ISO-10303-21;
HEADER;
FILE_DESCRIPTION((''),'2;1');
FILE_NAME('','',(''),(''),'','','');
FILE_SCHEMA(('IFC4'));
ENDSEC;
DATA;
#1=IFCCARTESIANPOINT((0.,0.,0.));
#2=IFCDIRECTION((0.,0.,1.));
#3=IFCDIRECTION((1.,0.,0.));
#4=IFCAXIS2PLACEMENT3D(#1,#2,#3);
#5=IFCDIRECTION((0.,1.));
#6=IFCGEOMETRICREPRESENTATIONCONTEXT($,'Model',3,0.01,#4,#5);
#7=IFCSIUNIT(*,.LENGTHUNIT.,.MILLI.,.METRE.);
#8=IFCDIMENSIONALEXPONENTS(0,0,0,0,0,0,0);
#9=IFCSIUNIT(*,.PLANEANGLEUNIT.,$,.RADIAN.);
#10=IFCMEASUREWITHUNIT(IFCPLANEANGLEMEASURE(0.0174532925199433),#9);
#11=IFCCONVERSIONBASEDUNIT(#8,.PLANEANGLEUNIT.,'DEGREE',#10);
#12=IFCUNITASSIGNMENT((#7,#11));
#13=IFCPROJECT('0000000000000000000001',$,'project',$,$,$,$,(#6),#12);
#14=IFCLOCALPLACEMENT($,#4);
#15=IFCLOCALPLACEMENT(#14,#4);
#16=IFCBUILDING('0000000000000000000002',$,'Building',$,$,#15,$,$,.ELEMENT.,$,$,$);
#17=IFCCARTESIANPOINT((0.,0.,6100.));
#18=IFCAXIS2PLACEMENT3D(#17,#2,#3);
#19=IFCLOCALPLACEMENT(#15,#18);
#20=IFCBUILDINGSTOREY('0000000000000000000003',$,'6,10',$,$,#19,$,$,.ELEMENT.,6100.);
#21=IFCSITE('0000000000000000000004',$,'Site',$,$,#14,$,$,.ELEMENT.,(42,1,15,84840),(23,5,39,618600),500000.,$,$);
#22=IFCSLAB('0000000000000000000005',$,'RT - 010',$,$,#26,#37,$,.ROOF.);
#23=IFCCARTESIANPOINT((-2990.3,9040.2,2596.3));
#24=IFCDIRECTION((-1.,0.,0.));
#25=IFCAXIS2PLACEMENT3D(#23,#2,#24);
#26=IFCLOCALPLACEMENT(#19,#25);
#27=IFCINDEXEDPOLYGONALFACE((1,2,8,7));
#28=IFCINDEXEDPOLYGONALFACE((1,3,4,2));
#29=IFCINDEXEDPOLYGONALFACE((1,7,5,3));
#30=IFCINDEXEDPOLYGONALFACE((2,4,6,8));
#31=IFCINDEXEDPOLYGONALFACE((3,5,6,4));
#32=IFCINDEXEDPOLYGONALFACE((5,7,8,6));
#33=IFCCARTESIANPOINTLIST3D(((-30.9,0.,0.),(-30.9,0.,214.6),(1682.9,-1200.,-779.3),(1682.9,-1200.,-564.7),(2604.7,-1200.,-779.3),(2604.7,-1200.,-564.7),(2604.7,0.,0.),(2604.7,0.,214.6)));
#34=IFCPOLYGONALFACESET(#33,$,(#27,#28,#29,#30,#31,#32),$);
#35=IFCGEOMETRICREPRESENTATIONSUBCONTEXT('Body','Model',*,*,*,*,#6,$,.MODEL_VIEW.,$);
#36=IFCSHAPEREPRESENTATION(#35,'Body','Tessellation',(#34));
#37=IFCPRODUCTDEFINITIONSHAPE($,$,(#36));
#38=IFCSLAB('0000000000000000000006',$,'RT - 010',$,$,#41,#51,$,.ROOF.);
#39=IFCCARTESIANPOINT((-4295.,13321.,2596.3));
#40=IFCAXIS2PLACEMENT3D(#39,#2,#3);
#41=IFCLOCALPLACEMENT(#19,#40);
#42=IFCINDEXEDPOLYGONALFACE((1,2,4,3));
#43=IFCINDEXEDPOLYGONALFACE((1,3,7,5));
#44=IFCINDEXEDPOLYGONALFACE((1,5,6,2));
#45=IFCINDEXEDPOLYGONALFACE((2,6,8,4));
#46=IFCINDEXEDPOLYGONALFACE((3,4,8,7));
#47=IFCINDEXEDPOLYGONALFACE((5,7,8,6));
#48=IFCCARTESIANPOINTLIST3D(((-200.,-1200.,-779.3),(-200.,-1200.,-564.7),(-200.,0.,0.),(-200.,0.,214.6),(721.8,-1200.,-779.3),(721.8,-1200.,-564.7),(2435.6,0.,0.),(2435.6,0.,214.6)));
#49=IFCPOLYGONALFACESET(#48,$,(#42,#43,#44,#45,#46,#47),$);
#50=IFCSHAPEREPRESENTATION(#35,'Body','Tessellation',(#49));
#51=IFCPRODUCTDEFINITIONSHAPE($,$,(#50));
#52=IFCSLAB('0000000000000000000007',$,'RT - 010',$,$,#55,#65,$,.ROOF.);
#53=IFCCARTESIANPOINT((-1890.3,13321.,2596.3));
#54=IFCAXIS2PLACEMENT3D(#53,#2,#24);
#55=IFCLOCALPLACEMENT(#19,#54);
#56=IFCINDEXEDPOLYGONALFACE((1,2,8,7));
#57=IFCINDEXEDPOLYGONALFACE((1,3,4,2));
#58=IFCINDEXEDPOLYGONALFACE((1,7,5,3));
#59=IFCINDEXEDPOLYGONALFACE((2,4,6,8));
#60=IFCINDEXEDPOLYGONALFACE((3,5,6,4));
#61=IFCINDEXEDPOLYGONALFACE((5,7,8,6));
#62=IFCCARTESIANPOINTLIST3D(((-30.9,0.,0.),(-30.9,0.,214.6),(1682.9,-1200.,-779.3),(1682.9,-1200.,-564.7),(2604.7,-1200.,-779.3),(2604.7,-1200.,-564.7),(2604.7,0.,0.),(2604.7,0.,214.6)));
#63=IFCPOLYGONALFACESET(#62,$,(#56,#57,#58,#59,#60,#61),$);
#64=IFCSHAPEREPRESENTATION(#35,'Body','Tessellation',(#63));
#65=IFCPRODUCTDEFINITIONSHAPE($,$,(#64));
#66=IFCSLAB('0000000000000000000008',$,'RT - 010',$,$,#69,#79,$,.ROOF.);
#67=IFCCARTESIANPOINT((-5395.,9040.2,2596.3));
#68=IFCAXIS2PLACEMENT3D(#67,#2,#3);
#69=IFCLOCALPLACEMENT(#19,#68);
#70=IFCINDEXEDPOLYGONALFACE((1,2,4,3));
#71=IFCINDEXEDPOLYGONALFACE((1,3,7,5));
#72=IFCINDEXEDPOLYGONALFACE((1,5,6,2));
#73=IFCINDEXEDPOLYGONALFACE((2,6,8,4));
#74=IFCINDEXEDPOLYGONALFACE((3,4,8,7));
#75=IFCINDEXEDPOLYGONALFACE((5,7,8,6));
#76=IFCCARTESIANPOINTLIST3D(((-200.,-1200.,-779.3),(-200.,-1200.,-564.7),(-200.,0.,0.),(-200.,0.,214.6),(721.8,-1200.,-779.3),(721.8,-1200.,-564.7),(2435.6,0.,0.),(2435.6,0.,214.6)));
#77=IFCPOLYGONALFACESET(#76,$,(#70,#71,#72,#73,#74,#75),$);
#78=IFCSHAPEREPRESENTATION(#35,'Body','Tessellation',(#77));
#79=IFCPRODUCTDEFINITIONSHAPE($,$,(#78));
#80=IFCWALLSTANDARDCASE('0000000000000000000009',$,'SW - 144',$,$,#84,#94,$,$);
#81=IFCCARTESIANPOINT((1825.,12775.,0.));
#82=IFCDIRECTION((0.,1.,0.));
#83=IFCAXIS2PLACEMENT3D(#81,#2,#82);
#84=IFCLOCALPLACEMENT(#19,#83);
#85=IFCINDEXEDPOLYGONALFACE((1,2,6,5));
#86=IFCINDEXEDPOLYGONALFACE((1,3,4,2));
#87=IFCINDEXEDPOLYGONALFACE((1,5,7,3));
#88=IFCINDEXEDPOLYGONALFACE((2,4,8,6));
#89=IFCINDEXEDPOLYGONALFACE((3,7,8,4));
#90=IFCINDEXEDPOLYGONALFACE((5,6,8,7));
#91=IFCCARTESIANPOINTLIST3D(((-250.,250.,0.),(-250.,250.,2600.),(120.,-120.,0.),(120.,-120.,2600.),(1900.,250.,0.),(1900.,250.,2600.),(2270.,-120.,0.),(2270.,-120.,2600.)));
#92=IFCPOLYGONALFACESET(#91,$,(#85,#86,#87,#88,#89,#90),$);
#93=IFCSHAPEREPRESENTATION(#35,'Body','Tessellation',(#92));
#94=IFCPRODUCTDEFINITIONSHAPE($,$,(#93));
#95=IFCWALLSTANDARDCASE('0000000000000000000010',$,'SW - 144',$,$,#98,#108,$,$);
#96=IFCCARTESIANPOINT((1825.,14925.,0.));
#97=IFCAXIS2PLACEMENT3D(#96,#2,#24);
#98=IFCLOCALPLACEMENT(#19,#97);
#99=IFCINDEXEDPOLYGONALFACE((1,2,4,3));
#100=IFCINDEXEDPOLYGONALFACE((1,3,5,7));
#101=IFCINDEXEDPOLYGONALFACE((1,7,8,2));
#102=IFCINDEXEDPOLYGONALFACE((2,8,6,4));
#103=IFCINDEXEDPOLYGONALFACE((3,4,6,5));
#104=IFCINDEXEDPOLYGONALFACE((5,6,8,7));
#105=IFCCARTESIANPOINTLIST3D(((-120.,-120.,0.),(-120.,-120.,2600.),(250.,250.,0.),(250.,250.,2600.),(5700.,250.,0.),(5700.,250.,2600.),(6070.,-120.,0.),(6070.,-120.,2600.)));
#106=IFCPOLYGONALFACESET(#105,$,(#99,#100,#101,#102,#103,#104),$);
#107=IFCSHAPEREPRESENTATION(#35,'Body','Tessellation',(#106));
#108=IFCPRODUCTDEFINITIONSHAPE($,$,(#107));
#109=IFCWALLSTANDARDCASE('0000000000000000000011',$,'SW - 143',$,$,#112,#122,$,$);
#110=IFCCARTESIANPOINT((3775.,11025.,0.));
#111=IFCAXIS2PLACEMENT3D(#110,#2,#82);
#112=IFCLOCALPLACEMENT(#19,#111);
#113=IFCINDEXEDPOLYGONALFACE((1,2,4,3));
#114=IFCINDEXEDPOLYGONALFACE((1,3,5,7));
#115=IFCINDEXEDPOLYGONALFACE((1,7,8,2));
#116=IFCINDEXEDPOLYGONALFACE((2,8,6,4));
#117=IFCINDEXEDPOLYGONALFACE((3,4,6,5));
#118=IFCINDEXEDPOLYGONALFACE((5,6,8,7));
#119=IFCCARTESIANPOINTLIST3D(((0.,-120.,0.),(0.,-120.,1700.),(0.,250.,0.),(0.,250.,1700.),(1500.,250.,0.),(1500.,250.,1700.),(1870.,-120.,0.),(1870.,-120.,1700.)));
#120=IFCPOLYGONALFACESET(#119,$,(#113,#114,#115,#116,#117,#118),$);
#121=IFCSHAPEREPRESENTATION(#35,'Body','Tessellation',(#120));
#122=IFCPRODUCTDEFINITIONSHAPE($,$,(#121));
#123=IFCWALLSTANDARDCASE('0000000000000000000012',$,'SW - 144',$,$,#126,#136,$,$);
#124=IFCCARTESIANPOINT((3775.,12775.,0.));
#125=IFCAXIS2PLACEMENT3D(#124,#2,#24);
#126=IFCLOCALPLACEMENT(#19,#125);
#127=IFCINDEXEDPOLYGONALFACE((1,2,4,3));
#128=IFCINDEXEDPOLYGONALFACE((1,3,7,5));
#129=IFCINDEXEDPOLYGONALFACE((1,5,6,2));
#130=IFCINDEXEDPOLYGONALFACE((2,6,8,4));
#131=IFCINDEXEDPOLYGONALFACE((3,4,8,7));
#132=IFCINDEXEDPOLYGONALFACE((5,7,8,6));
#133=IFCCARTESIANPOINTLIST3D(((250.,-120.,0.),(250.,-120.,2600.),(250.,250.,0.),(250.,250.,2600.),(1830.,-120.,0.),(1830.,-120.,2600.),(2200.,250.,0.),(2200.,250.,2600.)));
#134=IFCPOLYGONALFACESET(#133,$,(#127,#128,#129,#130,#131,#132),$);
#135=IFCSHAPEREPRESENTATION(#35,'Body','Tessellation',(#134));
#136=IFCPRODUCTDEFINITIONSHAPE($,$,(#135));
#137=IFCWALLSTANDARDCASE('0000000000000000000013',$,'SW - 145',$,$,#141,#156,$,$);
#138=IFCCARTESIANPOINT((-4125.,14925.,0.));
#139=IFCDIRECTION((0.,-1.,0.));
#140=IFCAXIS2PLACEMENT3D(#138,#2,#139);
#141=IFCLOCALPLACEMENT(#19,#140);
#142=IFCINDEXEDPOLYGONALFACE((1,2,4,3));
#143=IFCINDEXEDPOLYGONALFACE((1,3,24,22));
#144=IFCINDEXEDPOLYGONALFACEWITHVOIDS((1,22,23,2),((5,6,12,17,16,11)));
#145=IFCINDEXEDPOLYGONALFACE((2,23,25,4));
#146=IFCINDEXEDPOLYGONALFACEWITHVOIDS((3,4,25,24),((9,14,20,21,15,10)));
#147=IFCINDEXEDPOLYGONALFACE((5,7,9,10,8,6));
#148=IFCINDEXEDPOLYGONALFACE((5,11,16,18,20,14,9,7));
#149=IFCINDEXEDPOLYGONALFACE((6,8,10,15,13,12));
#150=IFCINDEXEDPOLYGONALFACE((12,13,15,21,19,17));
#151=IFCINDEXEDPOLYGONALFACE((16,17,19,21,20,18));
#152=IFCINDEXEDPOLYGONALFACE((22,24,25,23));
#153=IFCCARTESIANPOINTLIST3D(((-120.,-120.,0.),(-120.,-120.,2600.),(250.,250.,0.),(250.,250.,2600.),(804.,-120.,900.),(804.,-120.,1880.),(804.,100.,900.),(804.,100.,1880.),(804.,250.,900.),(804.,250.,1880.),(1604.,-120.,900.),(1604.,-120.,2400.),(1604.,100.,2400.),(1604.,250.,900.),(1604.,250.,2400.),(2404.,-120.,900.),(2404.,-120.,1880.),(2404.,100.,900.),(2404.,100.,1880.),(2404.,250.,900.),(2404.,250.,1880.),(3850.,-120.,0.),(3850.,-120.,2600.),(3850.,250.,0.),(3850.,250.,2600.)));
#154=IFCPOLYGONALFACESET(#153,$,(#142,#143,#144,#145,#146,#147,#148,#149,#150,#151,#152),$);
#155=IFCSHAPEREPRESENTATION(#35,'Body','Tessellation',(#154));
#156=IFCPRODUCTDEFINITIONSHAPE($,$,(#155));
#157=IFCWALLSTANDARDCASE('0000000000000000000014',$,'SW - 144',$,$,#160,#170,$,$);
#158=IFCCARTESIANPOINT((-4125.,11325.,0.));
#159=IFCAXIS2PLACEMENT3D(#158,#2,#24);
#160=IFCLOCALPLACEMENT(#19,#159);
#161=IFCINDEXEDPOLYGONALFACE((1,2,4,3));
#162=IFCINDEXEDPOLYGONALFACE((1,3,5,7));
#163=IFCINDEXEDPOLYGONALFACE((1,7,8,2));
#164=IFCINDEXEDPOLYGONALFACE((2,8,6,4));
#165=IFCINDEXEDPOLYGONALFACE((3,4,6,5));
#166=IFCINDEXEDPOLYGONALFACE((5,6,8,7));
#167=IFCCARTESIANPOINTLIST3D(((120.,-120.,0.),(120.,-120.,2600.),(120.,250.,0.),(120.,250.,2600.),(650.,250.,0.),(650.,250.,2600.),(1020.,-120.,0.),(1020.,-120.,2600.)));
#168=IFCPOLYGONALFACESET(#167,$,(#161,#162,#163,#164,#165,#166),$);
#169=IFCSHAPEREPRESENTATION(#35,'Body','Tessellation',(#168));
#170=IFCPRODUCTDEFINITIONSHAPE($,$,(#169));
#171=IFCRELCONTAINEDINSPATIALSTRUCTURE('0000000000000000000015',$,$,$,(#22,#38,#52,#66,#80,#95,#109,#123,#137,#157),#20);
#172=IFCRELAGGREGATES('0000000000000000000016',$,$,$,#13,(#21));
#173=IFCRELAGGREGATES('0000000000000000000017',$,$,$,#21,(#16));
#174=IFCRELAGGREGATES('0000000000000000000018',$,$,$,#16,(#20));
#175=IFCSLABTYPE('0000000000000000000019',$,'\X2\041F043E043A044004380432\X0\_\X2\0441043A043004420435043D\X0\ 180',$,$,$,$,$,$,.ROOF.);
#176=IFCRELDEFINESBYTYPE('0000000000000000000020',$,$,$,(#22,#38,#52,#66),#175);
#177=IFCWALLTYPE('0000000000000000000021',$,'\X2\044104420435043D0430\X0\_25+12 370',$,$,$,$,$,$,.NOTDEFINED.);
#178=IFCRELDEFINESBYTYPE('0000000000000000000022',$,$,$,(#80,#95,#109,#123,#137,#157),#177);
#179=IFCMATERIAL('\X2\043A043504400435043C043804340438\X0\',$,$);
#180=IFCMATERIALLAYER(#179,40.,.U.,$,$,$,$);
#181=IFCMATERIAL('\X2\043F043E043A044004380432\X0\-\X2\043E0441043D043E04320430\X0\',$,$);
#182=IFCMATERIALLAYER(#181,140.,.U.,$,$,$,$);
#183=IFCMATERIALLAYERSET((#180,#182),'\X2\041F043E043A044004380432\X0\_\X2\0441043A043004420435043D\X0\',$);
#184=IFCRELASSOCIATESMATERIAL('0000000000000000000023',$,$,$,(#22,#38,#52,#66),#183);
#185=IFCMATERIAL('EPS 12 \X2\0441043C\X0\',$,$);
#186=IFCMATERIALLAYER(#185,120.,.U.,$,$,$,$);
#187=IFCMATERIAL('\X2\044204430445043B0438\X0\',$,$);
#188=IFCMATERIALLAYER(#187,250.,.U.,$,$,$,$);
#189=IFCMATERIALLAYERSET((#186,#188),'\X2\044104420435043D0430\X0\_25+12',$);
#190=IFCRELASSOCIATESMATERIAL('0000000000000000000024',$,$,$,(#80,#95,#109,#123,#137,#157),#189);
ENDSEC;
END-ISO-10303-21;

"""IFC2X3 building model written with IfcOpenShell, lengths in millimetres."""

from ifc_helpers import new_model, entity, si_unit, converted_unit, direction, frame, origin_with_axes, place, context, subcontext, project, spatial, polyline, outline, extrude, material, layer, layer_set, layer_usage, type_object, element, save


model = new_model("IFC2X3")

# Units and contexts
model_context = context("Model", 3, precision=0.01, world=origin_with_axes(), true_north=direction((0.0, 1.0)))
body_context = subcontext(model_context, "Body", "Model", "MODEL_VIEW")
ifc_project = project(units=[si_unit("LENGTHUNIT", "METRE", prefix="MILLI"), converted_unit("PLANEANGLEUNIT", "DEGREE", entity("IfcPlaneAngleMeasure", 0.0174532925199433), si_unit("PLANEANGLEUNIT", "RADIAN"), dimensions=[0, 0, 0, 0, 0, 0, 0])], contexts=[model_context])

# Site, building, storey
site_placement = place(None, origin_with_axes())
site = spatial("IfcSite", under=ifc_project, at=site_placement, Name="Site", CompositionType="ELEMENT", RefLatitude=(42, 1, 15, 84840), RefLongitude=(23, 5, 39, 618600), RefElevation=500000.0)
building_placement = place(site_placement, origin_with_axes())
building = spatial("IfcBuilding", under=site, at=building_placement, Name="Building", CompositionType="ELEMENT")
storey_placement = place(building_placement, frame((0.0, 0.0, 6100.0), z_axis=(0.0, 0.0, 1.0), x_axis=(1.0, 0.0, 0.0)))
storey = spatial("IfcBuildingStorey", under=building, at=storey_placement, Name="6,10", CompositionType="ELEMENT", Elevation=6100.0)

# Slabs
ifc_material_1 = material(Name="керемиди")
ifc_layer_1 = layer(ifc_material_1, 40.0, ventilated="UNKNOWN")
ifc_material_2 = material(Name="покрив-основа")
ifc_layer_2 = layer(ifc_material_2, 140.0, ventilated="UNKNOWN")
ifc_layer_set_1 = layer_set([ifc_layer_1, ifc_layer_2], Name="Покрив_скатен")
ifc_layer_usage_1 = layer_usage(ifc_layer_set_1, "AXIS3", "NEGATIVE", 180.0)
slab_type = type_object("IfcSlabType", Name="Покрив_скатен 180", PredefinedType="ROOF")
slab_1_placement = place(storey_placement, frame((-2990.3, 9040.2, 2596.3), z_axis=(0.0, 0.0, 1.0), x_axis=(-1.0, 0.0, 0.0)))
element("IfcSlab", 1, at=slab_1_placement, inside=storey, type_object=slab_type, material=ifc_layer_usage_1, Name="RT - 010", PredefinedType="ROOF", context=body_context, shape_type="SweptSolid", body=[
    extrude(outline(polyline([(-30.9, 0.0), (1682.9, -1430.8), (2604.7, -1430.8), (2604.7, 0.0), (-30.9, 0.0)])), frame((0.0, 0.0, 0.0), z_axis=(0.0, -0.544639, 0.838671), x_axis=(1.0, 0.0, 0.0)), (0.0, 0.544639, 0.838671), 214.6),
])
ifc_layer_usage_2 = layer_usage(ifc_layer_set_1, "AXIS3", "NEGATIVE", 180.0)
slab_2_placement = place(storey_placement, frame((-4295.0, 13321.0, 2596.3), z_axis=(0.0, 0.0, 1.0), x_axis=(1.0, 0.0, 0.0)))
element("IfcSlab", 2, at=slab_2_placement, inside=storey, type_object=slab_type, material=ifc_layer_usage_2, Name="RT - 010", PredefinedType="ROOF", context=body_context, shape_type="SweptSolid", body=[
    extrude(outline(polyline([(2435.6, 0.0), (-200.0, 0.0), (-200.0, -1430.8), (721.8, -1430.8), (2435.6, 0.0)])), frame((0.0, 0.0, 0.0), z_axis=(0.0, -0.544639, 0.838671), x_axis=(1.0, 0.0, 0.0)), (0.0, 0.544639, 0.838671), 214.6),
])
ifc_layer_usage_3 = layer_usage(ifc_layer_set_1, "AXIS3", "NEGATIVE", 180.0)
slab_3_placement = place(storey_placement, frame((-1890.3, 13321.0, 2596.3), z_axis=(0.0, 0.0, 1.0), x_axis=(-1.0, 0.0, 0.0)))
element("IfcSlab", 3, at=slab_3_placement, inside=storey, type_object=slab_type, material=ifc_layer_usage_3, Name="RT - 010", PredefinedType="ROOF", context=body_context, shape_type="SweptSolid", body=[
    extrude(outline(polyline([(-30.9, 0.0), (1682.9, -1430.8), (2604.7, -1430.8), (2604.7, 0.0), (-30.9, 0.0)])), frame((0.0, 0.0, 0.0), z_axis=(0.0, -0.544639, 0.838671), x_axis=(1.0, 0.0, 0.0)), (0.0, 0.544639, 0.838671), 214.6),
])
ifc_layer_usage_4 = layer_usage(ifc_layer_set_1, "AXIS3", "NEGATIVE", 180.0)
slab_4_placement = place(storey_placement, frame((-5395.0, 9040.2, 2596.3), z_axis=(0.0, 0.0, 1.0), x_axis=(1.0, 0.0, 0.0)))
element("IfcSlab", 4, at=slab_4_placement, inside=storey, type_object=slab_type, material=ifc_layer_usage_4, Name="RT - 010", PredefinedType="ROOF", context=body_context, shape_type="SweptSolid", body=[
    extrude(outline(polyline([(2435.6, 0.0), (-200.0, 0.0), (-200.0, -1430.8), (721.8, -1430.8), (2435.6, 0.0)])), frame((0.0, 0.0, 0.0), z_axis=(0.0, -0.544639, 0.838671), x_axis=(1.0, 0.0, 0.0)), (0.0, 0.544639, 0.838671), 214.6),
])

# Walls
ifc_material_3 = material(Name="EPS 12 см")
ifc_layer_3 = layer(ifc_material_3, 120.0, ventilated="UNKNOWN")
ifc_material_4 = material(Name="тухли")
ifc_layer_4 = layer(ifc_material_4, 250.0, ventilated="UNKNOWN")
ifc_layer_set_2 = layer_set([ifc_layer_3, ifc_layer_4], Name="стена_25+12")
ifc_layer_usage_5 = layer_usage(ifc_layer_set_2, "AXIS2", "POSITIVE", -120.0)
wall_type_1 = type_object("IfcWallType", Name="стена_25+12 370", PredefinedType="NOTDEFINED")
wall_1_placement = place(storey_placement, frame((1825.0, 12775.0, 0.0), z_axis=(0.0, 0.0, 1.0), x_axis=(0.0, 1.0, 0.0)))
element("IfcWallStandardCase", 5, at=wall_1_placement, inside=storey, type_object=wall_type_1, material=ifc_layer_usage_5, Name="SW - 144", context=body_context, shape_type="SweptSolid", body=[
    extrude(outline(polyline([(120.0, -120.0), (2270.0, -120.0), (1900.0, 250.0), (-250.0, 250.0), (120.0, -120.0)])), origin_with_axes(), (0.0, 0.0, 1.0), 2600.0),
])
ifc_layer_usage_6 = layer_usage(ifc_layer_set_2, "AXIS2", "POSITIVE", -120.0)
wall_2_placement = place(storey_placement, frame((1825.0, 14925.0, 0.0), z_axis=(0.0, 0.0, 1.0), x_axis=(-1.0, 0.0, 0.0)))
element("IfcWallStandardCase", 6, at=wall_2_placement, inside=storey, type_object=wall_type_1, material=ifc_layer_usage_6, Name="SW - 144", context=body_context, shape_type="SweptSolid", body=[
    extrude(outline(polyline([(-120.0, -120.0), (6070.0, -120.0), (5700.0, 250.0), (250.0, 250.0), (-120.0, -120.0)])), origin_with_axes(), (0.0, 0.0, 1.0), 2600.0),
])
ifc_layer_usage_7 = layer_usage(ifc_layer_set_2, "AXIS2", "POSITIVE", -120.0)
wall_3_placement = place(storey_placement, frame((3775.0, 11025.0, 0.0), z_axis=(0.0, 0.0, 1.0), x_axis=(0.0, 1.0, 0.0)))
element("IfcWallStandardCase", 7, at=wall_3_placement, inside=storey, type_object=wall_type_1, material=ifc_layer_usage_7, Name="SW - 143", context=body_context, shape_type="SweptSolid", body=[
    extrude(outline(polyline([(0.0, -120.0), (1870.0, -120.0), (1500.0, 250.0), (0.0, 250.0), (0.0, -120.0)])), origin_with_axes(), (0.0, 0.0, 1.0), 1700.0),
])
ifc_layer_usage_8 = layer_usage(ifc_layer_set_2, "AXIS2", "POSITIVE", -120.0)
wall_4_placement = place(storey_placement, frame((3775.0, 12775.0, 0.0), z_axis=(0.0, 0.0, 1.0), x_axis=(-1.0, 0.0, 0.0)))
element("IfcWallStandardCase", 8, at=wall_4_placement, inside=storey, type_object=wall_type_1, material=ifc_layer_usage_8, Name="SW - 144", context=body_context, shape_type="SweptSolid", body=[
    extrude(outline(polyline([(250.0, -120.0), (1830.0, -120.0), (2200.0, 250.0), (250.0, 250.0), (250.0, -120.0)])), origin_with_axes(), (0.0, 0.0, 1.0), 2600.0),
])

# Wall, openings
ifc_layer_usage_9 = layer_usage(ifc_layer_set_2, "AXIS2", "POSITIVE", -120.0)
wall_5_placement = place(storey_placement, frame((-4125.0, 14925.0, 0.0), z_axis=(0.0, 0.0, 1.0), x_axis=(0.0, -1.0, 0.0)))
wall_5 = element("IfcWallStandardCase", 9, at=wall_5_placement, inside=storey, type_object=wall_type_1, material=ifc_layer_usage_9, Name="SW - 145", context=body_context, shape_type="SweptSolid", body=[
    extrude(outline(polyline([(-120.0, -120.0), (3850.0, -120.0), (3850.0, 250.0), (250.0, 250.0), (-120.0, -120.0)])), origin_with_axes(), (0.0, 0.0, 1.0), 2600.0),
])
opening_1_placement = place(wall_5_placement, frame((2004.0, 0.0, 900.0), z_axis=(0.0, 0.0, 1.0), x_axis=(1.0, 0.0, 0.0)))
element("IfcOpeningElement", 10, at=opening_1_placement, cuts=wall_5, context=body_context, shape_type="SweptSolid", body=[
    extrude(outline(polyline([(-400.0, 0.0), (-400.0, -1500.0), (400.0, -980.0), (400.0, 0.0), (-400.0, 0.0)])), frame((0.0, 100.0, 0.0), z_axis=(0.0, 1.0, 0.0), x_axis=(1.0, 0.0, 0.0)), (0.0, 0.0, -1.0), 590.0),
    extrude(outline(polyline([(400.0, 0.0), (400.0, 980.0), (-400.0, 1500.0), (-400.0, 0.0), (400.0, 0.0)])), frame((0.0, 100.0, 0.0), z_axis=(0.0, -1.0, 0.0), x_axis=(1.0, 0.0, 0.0)), (0.0, 0.0, -1.0), 520.0),
])
opening_2_placement = place(wall_5_placement, frame((1204.0, 0.0, 900.0), z_axis=(0.0, 0.0, 1.0), x_axis=(1.0, 0.0, 0.0)))
element("IfcOpeningElement", 11, at=opening_2_placement, cuts=wall_5, context=body_context, shape_type="SweptSolid", body=[
    extrude(outline(polyline([(-400.0, 0.0), (-400.0, -1500.0), (400.0, -980.0), (400.0, 0.0), (-400.0, 0.0)])), frame((0.0, 100.0, 0.0), z_axis=(0.0, -1.0, 0.0), x_axis=(-1.0, 0.0, 0.0)), (0.0, 0.0, 1.0), 590.0),
    extrude(outline(polyline([(400.0, 0.0), (400.0, 980.0), (-400.0, 1500.0), (-400.0, 0.0), (400.0, 0.0)])), frame((0.0, 100.0, 0.0), z_axis=(0.0, 1.0, 0.0), x_axis=(-1.0, 0.0, 0.0)), (0.0, 0.0, 1.0), 520.0),
])

# Wall
ifc_layer_usage_10 = layer_usage(ifc_layer_set_2, "AXIS2", "POSITIVE", -120.0)
wall_6_placement = place(storey_placement, frame((-4125.0, 11325.0, 0.0), z_axis=(0.0, 0.0, 1.0), x_axis=(-1.0, 0.0, 0.0)))
element("IfcWallStandardCase", 12, at=wall_6_placement, inside=storey, type_object=wall_type_1, material=ifc_layer_usage_10, Name="SW - 144", context=body_context, shape_type="SweptSolid", body=[
    extrude(outline(polyline([(120.0, -120.0), (1020.0, -120.0), (650.0, 250.0), (120.0, 250.0), (120.0, -120.0)])), origin_with_axes(), (0.0, 0.0, 1.0), 2600.0),
])

save(model, "model.ifc")
